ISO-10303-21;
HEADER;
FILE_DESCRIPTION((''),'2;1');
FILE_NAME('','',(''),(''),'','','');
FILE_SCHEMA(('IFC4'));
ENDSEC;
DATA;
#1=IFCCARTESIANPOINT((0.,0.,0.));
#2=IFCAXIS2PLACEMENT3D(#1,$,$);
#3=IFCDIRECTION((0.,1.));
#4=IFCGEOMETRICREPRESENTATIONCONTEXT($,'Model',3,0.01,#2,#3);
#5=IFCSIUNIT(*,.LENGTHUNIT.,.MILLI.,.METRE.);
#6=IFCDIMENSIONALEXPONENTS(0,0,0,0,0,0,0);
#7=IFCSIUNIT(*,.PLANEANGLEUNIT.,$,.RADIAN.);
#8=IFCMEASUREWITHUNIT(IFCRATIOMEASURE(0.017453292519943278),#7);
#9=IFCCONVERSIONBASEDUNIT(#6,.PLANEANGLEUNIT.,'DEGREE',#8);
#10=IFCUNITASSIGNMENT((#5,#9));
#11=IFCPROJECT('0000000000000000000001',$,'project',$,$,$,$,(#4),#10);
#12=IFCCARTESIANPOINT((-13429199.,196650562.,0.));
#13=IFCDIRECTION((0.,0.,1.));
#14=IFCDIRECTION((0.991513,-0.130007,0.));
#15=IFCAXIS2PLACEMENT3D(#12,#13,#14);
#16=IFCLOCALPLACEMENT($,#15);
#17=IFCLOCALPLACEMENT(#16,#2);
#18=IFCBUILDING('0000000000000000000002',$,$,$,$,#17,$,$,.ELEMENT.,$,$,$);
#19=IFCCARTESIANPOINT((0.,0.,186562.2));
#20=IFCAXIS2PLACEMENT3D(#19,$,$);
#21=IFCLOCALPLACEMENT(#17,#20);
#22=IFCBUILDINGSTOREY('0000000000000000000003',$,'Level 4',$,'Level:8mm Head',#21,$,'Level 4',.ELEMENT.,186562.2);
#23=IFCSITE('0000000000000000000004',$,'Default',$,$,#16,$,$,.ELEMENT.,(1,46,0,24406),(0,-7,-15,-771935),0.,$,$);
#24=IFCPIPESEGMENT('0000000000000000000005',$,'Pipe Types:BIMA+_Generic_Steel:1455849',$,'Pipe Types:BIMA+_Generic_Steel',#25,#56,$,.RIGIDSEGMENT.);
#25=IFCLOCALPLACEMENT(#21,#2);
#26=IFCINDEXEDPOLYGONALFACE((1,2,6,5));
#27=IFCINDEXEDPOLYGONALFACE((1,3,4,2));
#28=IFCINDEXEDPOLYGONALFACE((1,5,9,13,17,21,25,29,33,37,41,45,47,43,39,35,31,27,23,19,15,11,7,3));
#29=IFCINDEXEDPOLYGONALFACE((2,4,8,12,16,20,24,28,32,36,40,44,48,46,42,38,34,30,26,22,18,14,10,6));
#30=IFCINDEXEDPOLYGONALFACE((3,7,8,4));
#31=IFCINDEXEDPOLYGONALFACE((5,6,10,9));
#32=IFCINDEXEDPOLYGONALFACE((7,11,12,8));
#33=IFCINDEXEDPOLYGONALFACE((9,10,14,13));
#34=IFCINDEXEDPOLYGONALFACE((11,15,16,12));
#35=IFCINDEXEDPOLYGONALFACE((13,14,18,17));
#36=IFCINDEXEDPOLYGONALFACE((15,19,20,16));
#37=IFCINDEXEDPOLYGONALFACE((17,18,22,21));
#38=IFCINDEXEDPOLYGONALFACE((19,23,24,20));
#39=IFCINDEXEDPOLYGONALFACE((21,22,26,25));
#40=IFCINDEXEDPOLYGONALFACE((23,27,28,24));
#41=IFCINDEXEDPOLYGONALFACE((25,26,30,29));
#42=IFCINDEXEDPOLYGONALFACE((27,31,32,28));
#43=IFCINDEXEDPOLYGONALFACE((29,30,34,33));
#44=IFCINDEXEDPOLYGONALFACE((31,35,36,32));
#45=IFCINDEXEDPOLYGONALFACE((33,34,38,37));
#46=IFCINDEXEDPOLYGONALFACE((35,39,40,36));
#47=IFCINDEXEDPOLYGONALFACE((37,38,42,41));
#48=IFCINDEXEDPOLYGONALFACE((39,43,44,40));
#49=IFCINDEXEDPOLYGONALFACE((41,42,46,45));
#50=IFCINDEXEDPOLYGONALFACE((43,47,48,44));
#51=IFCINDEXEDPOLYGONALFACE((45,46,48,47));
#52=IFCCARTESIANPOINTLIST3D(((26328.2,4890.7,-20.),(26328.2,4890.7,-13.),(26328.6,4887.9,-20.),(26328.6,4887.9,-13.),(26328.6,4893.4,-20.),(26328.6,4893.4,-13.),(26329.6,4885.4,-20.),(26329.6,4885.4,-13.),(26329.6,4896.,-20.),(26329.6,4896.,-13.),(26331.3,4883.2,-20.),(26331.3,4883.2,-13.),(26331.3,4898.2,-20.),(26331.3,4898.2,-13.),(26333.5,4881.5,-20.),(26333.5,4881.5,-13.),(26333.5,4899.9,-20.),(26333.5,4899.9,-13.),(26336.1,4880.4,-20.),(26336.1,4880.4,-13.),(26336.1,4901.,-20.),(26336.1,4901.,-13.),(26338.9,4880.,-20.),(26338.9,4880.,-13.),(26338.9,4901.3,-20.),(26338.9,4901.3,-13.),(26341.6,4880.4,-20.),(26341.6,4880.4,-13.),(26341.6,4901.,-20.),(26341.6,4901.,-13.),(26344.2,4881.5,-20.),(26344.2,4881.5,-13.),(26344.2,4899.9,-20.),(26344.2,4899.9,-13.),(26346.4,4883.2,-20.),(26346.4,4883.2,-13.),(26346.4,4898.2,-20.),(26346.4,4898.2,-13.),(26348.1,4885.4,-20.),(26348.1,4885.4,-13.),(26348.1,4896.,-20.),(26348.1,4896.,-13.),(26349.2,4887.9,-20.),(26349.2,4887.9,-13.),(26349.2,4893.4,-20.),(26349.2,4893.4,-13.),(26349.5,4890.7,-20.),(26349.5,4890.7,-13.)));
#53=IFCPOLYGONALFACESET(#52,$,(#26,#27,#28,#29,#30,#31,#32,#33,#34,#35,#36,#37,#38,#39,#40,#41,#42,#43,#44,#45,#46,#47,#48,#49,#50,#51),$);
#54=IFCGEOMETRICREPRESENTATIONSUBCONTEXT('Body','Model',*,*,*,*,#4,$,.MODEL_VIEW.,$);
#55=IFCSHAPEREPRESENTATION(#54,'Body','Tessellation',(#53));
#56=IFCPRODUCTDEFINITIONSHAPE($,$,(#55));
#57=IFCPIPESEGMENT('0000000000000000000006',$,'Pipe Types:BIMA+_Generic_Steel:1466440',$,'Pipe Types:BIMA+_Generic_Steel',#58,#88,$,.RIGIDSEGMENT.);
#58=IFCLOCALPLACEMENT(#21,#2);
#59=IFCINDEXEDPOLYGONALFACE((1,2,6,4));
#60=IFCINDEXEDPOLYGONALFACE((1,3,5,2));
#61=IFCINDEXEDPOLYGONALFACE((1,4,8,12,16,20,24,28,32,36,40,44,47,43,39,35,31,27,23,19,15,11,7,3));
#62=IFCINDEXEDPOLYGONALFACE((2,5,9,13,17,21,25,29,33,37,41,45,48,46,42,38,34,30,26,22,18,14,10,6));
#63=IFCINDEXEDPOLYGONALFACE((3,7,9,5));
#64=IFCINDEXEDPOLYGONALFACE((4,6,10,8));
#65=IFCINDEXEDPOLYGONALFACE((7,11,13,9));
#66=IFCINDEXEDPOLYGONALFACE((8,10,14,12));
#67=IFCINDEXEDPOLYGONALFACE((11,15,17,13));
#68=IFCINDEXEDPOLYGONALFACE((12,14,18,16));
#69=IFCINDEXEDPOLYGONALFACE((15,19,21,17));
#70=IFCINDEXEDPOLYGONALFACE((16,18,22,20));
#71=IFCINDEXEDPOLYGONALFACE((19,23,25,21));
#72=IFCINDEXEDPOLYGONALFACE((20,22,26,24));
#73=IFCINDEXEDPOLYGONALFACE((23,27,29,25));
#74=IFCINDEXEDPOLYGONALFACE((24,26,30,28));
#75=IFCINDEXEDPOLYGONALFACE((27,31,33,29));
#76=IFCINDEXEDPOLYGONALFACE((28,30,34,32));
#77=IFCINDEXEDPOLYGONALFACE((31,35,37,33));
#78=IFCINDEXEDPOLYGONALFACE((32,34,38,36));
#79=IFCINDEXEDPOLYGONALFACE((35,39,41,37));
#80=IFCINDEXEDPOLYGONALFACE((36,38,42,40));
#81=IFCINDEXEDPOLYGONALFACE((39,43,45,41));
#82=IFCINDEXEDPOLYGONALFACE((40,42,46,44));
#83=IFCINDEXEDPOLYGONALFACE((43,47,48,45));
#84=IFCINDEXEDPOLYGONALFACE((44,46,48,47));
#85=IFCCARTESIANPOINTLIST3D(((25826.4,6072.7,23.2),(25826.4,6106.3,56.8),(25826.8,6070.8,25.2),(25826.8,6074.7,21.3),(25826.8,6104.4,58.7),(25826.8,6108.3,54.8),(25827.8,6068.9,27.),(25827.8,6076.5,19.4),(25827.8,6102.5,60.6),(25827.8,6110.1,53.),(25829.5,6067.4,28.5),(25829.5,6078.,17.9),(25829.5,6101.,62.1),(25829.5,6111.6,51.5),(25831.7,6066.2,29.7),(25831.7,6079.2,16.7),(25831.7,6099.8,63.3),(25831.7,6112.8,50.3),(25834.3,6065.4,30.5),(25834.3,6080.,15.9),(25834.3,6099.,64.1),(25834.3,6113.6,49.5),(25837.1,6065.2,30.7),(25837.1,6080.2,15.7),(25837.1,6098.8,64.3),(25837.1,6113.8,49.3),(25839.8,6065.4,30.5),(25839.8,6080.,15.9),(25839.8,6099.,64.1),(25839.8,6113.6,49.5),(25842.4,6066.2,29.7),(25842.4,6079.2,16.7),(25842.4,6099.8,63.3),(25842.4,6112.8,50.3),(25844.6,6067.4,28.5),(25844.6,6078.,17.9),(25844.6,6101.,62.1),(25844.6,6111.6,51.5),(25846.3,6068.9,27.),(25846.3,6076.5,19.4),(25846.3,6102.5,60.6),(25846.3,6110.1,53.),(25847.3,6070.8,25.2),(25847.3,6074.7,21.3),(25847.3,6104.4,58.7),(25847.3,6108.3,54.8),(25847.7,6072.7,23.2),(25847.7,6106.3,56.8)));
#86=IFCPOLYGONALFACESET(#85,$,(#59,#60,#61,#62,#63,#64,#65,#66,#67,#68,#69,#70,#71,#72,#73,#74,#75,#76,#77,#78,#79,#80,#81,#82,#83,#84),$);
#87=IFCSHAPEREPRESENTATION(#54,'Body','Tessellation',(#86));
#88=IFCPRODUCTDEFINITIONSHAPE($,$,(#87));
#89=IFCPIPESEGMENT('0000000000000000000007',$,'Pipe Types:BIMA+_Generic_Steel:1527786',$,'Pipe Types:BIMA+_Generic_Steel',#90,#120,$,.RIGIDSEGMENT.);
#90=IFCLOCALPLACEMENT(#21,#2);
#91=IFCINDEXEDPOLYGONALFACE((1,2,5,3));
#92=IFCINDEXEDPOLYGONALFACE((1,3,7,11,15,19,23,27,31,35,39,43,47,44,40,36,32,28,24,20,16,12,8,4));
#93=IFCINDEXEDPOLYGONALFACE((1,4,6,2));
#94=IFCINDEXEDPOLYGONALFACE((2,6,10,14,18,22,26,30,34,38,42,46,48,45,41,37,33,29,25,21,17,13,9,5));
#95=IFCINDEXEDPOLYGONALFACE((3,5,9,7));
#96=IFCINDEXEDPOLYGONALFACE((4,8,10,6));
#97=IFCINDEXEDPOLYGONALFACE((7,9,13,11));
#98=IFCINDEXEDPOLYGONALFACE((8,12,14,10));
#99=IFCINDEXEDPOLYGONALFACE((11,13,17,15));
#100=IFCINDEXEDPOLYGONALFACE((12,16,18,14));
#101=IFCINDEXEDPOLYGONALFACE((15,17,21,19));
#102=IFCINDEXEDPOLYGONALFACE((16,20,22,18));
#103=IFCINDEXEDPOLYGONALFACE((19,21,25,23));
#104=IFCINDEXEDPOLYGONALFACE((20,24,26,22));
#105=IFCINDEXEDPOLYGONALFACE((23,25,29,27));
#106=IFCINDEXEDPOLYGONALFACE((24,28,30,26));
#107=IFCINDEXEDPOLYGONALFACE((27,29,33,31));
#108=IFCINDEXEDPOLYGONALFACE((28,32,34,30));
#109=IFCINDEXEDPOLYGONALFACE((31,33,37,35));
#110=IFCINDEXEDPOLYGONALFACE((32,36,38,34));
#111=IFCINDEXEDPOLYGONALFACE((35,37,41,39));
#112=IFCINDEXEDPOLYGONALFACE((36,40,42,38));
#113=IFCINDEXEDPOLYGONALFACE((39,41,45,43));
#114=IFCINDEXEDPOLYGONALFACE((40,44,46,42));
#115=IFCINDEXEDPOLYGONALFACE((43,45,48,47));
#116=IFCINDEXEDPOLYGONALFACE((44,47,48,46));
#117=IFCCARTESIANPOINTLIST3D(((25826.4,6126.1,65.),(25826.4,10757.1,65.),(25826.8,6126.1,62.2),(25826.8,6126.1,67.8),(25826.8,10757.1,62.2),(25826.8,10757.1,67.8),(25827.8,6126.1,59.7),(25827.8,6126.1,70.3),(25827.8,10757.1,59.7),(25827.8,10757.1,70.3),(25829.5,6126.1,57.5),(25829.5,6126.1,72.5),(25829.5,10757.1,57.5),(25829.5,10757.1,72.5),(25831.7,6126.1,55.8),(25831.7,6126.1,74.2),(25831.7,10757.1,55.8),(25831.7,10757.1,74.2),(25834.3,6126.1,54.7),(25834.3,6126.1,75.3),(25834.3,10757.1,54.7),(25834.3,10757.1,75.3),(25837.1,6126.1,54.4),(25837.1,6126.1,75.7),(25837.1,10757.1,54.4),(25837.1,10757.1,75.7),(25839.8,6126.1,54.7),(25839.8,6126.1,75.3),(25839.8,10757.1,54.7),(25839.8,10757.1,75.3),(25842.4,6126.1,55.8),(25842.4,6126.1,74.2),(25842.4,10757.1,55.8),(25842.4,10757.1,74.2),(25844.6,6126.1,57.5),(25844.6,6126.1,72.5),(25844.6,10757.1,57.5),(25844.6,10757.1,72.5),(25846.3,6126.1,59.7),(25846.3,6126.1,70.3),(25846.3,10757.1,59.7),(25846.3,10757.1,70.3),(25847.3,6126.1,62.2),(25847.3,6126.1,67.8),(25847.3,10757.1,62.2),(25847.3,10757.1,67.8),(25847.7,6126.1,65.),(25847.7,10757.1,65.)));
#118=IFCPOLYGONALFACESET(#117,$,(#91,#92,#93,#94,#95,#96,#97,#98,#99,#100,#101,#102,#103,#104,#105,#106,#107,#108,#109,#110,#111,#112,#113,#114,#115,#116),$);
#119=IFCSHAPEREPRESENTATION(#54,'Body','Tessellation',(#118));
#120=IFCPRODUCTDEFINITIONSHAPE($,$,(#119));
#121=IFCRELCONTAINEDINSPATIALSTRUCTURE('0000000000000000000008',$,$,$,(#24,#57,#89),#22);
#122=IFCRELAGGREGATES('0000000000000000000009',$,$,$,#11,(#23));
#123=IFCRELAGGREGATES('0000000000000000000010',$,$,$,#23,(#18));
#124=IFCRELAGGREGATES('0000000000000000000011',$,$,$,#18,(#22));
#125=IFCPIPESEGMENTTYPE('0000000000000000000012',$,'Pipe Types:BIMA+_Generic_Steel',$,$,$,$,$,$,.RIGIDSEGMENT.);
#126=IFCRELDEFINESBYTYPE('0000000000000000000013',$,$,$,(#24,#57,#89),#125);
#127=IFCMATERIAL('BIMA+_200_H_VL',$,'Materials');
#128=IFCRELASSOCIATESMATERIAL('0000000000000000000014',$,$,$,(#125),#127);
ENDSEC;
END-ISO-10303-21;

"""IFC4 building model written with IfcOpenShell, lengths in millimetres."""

from ifc_helpers import new_model, entity, si_unit, converted_unit, direction, frame, origin, place, context, subcontext, project, spatial, arc, indexed_curve, outline, extrude, material, type_object, element, save


model = new_model("IFC4")

# Units and contexts
model_context = context("Model", 3, precision=0.01, world=origin(), true_north=direction((0.0, 1.0)))
body_context = subcontext(model_context, "Body", "Model", "MODEL_VIEW")
ifc_project = project(units=[si_unit("LENGTHUNIT", "METRE", prefix="MILLI"), converted_unit("PLANEANGLEUNIT", "DEGREE", entity("IfcRatioMeasure", 0.017453292519943278), si_unit("PLANEANGLEUNIT", "RADIAN"), dimensions=[0, 0, 0, 0, 0, 0, 0])], contexts=[model_context])

# Site, building, storey
site_placement = place(None, frame((-13429199.0, 196650562.0, 0.0), z_axis=(0.0, 0.0, 1.0), x_axis=(0.991513, -0.130007, 0.0)))
site = spatial("IfcSite", under=ifc_project, at=site_placement, Name="Default", CompositionType="ELEMENT", RefLatitude=(1, 46, 0, 24406), RefLongitude=(0, -7, -15, -771935), RefElevation=0.0)
building_placement = place(site_placement, origin())
building = spatial("IfcBuilding", under=site, at=building_placement, CompositionType="ELEMENT")
storey_placement = place(building_placement, frame((0.0, 0.0, 186562.2)))
storey = spatial("IfcBuildingStorey", under=building, at=storey_placement, Name="Level 4", ObjectType="Level:8mm Head", LongName="Level 4", CompositionType="ELEMENT", Elevation=186562.2)

# Pipe segments
ifc_material = material(Name="BIMA+_200_H_VL", Category="Materials")
pipe_segment_type = type_object("IfcPipeSegmentType", Name="Pipe Types:BIMA+_Generic_Steel", PredefinedType="RIGIDSEGMENT", material=ifc_material)
pipe_segment_1_placement = place(storey_placement, frame((26326.6, 4878.4, -13.0)))
element("IfcPipeSegment", 1, at=pipe_segment_1_placement, inside=storey, type_object=pipe_segment_type, Name="Pipe Types:BIMA+_Generic_Steel:1455849", ObjectType="Pipe Types:BIMA+_Generic_Steel", PredefinedType="RIGIDSEGMENT", context=body_context, shape_type="SweptSolid", body=[
    extrude(outline(indexed_curve([(10.7, 0.0), (7.5, 7.5), (0.0, 10.6), (-7.5, 7.5), (-10.7, 0.0), (-7.5, -7.5), (0.0, -10.6), (7.5, -7.5)], segments=[arc(1, 2, 3), arc(3, 4, 5), arc(5, 6, 7), arc(7, 8, 1)], self_intersect=False)), frame((12.2, 12.2, -7.0)), (0.0, 0.0, 1.0), 7.0),
])
pipe_segment_2_placement = place(storey_placement, frame((25824.8, 6063.6, 14.1)))
element("IfcPipeSegment", 2, at=pipe_segment_2_placement, inside=storey, type_object=pipe_segment_type, Name="Pipe Types:BIMA+_Generic_Steel:1466440", ObjectType="Pipe Types:BIMA+_Generic_Steel", PredefinedType="RIGIDSEGMENT", context=body_context, shape_type="SweptSolid", body=[
    extrude(outline(indexed_curve([(10.7, 0.0), (7.5, 7.5), (0.0, 10.7), (-7.5, 7.5), (-10.7, 0.0), (-7.5, -7.5), (0.0, -10.7), (7.5, -7.5)], segments=[arc(1, 2, 3), arc(3, 4, 5), arc(5, 6, 7), arc(7, 8, 1)], self_intersect=False)), frame((12.2, 9.1, 9.1), z_axis=(0.0, 0.707107, 0.707107), x_axis=(1.0, 0.0, 0.0)), (0.0, 0.0, 1.0), 47.5),
])
pipe_segment_3_placement = place(storey_placement, frame((25824.8, 6126.1, 52.8)))
element("IfcPipeSegment", 3, at=pipe_segment_3_placement, inside=storey, type_object=pipe_segment_type, Name="Pipe Types:BIMA+_Generic_Steel:1527786", ObjectType="Pipe Types:BIMA+_Generic_Steel", PredefinedType="RIGIDSEGMENT", context=body_context, shape_type="SweptSolid", body=[
    extrude(outline(indexed_curve([(10.6, 0.0), (7.5, 7.5), (0.0, 10.7), (-7.5, 7.5), (-10.7, 0.0), (-7.5, -7.5), (0.0, -10.7), (7.5, -7.5)], segments=[arc(1, 2, 3), arc(3, 4, 5), arc(5, 6, 7), arc(7, 8, 1)], self_intersect=False)), frame((12.2, 0.0, 12.2), z_axis=(0.0, 1.0, 0.0), x_axis=(-1.0, 0.0, 0.0)), (0.0, 0.0, 1.0), 4631.0),
])

save(model, "model.ifc")
